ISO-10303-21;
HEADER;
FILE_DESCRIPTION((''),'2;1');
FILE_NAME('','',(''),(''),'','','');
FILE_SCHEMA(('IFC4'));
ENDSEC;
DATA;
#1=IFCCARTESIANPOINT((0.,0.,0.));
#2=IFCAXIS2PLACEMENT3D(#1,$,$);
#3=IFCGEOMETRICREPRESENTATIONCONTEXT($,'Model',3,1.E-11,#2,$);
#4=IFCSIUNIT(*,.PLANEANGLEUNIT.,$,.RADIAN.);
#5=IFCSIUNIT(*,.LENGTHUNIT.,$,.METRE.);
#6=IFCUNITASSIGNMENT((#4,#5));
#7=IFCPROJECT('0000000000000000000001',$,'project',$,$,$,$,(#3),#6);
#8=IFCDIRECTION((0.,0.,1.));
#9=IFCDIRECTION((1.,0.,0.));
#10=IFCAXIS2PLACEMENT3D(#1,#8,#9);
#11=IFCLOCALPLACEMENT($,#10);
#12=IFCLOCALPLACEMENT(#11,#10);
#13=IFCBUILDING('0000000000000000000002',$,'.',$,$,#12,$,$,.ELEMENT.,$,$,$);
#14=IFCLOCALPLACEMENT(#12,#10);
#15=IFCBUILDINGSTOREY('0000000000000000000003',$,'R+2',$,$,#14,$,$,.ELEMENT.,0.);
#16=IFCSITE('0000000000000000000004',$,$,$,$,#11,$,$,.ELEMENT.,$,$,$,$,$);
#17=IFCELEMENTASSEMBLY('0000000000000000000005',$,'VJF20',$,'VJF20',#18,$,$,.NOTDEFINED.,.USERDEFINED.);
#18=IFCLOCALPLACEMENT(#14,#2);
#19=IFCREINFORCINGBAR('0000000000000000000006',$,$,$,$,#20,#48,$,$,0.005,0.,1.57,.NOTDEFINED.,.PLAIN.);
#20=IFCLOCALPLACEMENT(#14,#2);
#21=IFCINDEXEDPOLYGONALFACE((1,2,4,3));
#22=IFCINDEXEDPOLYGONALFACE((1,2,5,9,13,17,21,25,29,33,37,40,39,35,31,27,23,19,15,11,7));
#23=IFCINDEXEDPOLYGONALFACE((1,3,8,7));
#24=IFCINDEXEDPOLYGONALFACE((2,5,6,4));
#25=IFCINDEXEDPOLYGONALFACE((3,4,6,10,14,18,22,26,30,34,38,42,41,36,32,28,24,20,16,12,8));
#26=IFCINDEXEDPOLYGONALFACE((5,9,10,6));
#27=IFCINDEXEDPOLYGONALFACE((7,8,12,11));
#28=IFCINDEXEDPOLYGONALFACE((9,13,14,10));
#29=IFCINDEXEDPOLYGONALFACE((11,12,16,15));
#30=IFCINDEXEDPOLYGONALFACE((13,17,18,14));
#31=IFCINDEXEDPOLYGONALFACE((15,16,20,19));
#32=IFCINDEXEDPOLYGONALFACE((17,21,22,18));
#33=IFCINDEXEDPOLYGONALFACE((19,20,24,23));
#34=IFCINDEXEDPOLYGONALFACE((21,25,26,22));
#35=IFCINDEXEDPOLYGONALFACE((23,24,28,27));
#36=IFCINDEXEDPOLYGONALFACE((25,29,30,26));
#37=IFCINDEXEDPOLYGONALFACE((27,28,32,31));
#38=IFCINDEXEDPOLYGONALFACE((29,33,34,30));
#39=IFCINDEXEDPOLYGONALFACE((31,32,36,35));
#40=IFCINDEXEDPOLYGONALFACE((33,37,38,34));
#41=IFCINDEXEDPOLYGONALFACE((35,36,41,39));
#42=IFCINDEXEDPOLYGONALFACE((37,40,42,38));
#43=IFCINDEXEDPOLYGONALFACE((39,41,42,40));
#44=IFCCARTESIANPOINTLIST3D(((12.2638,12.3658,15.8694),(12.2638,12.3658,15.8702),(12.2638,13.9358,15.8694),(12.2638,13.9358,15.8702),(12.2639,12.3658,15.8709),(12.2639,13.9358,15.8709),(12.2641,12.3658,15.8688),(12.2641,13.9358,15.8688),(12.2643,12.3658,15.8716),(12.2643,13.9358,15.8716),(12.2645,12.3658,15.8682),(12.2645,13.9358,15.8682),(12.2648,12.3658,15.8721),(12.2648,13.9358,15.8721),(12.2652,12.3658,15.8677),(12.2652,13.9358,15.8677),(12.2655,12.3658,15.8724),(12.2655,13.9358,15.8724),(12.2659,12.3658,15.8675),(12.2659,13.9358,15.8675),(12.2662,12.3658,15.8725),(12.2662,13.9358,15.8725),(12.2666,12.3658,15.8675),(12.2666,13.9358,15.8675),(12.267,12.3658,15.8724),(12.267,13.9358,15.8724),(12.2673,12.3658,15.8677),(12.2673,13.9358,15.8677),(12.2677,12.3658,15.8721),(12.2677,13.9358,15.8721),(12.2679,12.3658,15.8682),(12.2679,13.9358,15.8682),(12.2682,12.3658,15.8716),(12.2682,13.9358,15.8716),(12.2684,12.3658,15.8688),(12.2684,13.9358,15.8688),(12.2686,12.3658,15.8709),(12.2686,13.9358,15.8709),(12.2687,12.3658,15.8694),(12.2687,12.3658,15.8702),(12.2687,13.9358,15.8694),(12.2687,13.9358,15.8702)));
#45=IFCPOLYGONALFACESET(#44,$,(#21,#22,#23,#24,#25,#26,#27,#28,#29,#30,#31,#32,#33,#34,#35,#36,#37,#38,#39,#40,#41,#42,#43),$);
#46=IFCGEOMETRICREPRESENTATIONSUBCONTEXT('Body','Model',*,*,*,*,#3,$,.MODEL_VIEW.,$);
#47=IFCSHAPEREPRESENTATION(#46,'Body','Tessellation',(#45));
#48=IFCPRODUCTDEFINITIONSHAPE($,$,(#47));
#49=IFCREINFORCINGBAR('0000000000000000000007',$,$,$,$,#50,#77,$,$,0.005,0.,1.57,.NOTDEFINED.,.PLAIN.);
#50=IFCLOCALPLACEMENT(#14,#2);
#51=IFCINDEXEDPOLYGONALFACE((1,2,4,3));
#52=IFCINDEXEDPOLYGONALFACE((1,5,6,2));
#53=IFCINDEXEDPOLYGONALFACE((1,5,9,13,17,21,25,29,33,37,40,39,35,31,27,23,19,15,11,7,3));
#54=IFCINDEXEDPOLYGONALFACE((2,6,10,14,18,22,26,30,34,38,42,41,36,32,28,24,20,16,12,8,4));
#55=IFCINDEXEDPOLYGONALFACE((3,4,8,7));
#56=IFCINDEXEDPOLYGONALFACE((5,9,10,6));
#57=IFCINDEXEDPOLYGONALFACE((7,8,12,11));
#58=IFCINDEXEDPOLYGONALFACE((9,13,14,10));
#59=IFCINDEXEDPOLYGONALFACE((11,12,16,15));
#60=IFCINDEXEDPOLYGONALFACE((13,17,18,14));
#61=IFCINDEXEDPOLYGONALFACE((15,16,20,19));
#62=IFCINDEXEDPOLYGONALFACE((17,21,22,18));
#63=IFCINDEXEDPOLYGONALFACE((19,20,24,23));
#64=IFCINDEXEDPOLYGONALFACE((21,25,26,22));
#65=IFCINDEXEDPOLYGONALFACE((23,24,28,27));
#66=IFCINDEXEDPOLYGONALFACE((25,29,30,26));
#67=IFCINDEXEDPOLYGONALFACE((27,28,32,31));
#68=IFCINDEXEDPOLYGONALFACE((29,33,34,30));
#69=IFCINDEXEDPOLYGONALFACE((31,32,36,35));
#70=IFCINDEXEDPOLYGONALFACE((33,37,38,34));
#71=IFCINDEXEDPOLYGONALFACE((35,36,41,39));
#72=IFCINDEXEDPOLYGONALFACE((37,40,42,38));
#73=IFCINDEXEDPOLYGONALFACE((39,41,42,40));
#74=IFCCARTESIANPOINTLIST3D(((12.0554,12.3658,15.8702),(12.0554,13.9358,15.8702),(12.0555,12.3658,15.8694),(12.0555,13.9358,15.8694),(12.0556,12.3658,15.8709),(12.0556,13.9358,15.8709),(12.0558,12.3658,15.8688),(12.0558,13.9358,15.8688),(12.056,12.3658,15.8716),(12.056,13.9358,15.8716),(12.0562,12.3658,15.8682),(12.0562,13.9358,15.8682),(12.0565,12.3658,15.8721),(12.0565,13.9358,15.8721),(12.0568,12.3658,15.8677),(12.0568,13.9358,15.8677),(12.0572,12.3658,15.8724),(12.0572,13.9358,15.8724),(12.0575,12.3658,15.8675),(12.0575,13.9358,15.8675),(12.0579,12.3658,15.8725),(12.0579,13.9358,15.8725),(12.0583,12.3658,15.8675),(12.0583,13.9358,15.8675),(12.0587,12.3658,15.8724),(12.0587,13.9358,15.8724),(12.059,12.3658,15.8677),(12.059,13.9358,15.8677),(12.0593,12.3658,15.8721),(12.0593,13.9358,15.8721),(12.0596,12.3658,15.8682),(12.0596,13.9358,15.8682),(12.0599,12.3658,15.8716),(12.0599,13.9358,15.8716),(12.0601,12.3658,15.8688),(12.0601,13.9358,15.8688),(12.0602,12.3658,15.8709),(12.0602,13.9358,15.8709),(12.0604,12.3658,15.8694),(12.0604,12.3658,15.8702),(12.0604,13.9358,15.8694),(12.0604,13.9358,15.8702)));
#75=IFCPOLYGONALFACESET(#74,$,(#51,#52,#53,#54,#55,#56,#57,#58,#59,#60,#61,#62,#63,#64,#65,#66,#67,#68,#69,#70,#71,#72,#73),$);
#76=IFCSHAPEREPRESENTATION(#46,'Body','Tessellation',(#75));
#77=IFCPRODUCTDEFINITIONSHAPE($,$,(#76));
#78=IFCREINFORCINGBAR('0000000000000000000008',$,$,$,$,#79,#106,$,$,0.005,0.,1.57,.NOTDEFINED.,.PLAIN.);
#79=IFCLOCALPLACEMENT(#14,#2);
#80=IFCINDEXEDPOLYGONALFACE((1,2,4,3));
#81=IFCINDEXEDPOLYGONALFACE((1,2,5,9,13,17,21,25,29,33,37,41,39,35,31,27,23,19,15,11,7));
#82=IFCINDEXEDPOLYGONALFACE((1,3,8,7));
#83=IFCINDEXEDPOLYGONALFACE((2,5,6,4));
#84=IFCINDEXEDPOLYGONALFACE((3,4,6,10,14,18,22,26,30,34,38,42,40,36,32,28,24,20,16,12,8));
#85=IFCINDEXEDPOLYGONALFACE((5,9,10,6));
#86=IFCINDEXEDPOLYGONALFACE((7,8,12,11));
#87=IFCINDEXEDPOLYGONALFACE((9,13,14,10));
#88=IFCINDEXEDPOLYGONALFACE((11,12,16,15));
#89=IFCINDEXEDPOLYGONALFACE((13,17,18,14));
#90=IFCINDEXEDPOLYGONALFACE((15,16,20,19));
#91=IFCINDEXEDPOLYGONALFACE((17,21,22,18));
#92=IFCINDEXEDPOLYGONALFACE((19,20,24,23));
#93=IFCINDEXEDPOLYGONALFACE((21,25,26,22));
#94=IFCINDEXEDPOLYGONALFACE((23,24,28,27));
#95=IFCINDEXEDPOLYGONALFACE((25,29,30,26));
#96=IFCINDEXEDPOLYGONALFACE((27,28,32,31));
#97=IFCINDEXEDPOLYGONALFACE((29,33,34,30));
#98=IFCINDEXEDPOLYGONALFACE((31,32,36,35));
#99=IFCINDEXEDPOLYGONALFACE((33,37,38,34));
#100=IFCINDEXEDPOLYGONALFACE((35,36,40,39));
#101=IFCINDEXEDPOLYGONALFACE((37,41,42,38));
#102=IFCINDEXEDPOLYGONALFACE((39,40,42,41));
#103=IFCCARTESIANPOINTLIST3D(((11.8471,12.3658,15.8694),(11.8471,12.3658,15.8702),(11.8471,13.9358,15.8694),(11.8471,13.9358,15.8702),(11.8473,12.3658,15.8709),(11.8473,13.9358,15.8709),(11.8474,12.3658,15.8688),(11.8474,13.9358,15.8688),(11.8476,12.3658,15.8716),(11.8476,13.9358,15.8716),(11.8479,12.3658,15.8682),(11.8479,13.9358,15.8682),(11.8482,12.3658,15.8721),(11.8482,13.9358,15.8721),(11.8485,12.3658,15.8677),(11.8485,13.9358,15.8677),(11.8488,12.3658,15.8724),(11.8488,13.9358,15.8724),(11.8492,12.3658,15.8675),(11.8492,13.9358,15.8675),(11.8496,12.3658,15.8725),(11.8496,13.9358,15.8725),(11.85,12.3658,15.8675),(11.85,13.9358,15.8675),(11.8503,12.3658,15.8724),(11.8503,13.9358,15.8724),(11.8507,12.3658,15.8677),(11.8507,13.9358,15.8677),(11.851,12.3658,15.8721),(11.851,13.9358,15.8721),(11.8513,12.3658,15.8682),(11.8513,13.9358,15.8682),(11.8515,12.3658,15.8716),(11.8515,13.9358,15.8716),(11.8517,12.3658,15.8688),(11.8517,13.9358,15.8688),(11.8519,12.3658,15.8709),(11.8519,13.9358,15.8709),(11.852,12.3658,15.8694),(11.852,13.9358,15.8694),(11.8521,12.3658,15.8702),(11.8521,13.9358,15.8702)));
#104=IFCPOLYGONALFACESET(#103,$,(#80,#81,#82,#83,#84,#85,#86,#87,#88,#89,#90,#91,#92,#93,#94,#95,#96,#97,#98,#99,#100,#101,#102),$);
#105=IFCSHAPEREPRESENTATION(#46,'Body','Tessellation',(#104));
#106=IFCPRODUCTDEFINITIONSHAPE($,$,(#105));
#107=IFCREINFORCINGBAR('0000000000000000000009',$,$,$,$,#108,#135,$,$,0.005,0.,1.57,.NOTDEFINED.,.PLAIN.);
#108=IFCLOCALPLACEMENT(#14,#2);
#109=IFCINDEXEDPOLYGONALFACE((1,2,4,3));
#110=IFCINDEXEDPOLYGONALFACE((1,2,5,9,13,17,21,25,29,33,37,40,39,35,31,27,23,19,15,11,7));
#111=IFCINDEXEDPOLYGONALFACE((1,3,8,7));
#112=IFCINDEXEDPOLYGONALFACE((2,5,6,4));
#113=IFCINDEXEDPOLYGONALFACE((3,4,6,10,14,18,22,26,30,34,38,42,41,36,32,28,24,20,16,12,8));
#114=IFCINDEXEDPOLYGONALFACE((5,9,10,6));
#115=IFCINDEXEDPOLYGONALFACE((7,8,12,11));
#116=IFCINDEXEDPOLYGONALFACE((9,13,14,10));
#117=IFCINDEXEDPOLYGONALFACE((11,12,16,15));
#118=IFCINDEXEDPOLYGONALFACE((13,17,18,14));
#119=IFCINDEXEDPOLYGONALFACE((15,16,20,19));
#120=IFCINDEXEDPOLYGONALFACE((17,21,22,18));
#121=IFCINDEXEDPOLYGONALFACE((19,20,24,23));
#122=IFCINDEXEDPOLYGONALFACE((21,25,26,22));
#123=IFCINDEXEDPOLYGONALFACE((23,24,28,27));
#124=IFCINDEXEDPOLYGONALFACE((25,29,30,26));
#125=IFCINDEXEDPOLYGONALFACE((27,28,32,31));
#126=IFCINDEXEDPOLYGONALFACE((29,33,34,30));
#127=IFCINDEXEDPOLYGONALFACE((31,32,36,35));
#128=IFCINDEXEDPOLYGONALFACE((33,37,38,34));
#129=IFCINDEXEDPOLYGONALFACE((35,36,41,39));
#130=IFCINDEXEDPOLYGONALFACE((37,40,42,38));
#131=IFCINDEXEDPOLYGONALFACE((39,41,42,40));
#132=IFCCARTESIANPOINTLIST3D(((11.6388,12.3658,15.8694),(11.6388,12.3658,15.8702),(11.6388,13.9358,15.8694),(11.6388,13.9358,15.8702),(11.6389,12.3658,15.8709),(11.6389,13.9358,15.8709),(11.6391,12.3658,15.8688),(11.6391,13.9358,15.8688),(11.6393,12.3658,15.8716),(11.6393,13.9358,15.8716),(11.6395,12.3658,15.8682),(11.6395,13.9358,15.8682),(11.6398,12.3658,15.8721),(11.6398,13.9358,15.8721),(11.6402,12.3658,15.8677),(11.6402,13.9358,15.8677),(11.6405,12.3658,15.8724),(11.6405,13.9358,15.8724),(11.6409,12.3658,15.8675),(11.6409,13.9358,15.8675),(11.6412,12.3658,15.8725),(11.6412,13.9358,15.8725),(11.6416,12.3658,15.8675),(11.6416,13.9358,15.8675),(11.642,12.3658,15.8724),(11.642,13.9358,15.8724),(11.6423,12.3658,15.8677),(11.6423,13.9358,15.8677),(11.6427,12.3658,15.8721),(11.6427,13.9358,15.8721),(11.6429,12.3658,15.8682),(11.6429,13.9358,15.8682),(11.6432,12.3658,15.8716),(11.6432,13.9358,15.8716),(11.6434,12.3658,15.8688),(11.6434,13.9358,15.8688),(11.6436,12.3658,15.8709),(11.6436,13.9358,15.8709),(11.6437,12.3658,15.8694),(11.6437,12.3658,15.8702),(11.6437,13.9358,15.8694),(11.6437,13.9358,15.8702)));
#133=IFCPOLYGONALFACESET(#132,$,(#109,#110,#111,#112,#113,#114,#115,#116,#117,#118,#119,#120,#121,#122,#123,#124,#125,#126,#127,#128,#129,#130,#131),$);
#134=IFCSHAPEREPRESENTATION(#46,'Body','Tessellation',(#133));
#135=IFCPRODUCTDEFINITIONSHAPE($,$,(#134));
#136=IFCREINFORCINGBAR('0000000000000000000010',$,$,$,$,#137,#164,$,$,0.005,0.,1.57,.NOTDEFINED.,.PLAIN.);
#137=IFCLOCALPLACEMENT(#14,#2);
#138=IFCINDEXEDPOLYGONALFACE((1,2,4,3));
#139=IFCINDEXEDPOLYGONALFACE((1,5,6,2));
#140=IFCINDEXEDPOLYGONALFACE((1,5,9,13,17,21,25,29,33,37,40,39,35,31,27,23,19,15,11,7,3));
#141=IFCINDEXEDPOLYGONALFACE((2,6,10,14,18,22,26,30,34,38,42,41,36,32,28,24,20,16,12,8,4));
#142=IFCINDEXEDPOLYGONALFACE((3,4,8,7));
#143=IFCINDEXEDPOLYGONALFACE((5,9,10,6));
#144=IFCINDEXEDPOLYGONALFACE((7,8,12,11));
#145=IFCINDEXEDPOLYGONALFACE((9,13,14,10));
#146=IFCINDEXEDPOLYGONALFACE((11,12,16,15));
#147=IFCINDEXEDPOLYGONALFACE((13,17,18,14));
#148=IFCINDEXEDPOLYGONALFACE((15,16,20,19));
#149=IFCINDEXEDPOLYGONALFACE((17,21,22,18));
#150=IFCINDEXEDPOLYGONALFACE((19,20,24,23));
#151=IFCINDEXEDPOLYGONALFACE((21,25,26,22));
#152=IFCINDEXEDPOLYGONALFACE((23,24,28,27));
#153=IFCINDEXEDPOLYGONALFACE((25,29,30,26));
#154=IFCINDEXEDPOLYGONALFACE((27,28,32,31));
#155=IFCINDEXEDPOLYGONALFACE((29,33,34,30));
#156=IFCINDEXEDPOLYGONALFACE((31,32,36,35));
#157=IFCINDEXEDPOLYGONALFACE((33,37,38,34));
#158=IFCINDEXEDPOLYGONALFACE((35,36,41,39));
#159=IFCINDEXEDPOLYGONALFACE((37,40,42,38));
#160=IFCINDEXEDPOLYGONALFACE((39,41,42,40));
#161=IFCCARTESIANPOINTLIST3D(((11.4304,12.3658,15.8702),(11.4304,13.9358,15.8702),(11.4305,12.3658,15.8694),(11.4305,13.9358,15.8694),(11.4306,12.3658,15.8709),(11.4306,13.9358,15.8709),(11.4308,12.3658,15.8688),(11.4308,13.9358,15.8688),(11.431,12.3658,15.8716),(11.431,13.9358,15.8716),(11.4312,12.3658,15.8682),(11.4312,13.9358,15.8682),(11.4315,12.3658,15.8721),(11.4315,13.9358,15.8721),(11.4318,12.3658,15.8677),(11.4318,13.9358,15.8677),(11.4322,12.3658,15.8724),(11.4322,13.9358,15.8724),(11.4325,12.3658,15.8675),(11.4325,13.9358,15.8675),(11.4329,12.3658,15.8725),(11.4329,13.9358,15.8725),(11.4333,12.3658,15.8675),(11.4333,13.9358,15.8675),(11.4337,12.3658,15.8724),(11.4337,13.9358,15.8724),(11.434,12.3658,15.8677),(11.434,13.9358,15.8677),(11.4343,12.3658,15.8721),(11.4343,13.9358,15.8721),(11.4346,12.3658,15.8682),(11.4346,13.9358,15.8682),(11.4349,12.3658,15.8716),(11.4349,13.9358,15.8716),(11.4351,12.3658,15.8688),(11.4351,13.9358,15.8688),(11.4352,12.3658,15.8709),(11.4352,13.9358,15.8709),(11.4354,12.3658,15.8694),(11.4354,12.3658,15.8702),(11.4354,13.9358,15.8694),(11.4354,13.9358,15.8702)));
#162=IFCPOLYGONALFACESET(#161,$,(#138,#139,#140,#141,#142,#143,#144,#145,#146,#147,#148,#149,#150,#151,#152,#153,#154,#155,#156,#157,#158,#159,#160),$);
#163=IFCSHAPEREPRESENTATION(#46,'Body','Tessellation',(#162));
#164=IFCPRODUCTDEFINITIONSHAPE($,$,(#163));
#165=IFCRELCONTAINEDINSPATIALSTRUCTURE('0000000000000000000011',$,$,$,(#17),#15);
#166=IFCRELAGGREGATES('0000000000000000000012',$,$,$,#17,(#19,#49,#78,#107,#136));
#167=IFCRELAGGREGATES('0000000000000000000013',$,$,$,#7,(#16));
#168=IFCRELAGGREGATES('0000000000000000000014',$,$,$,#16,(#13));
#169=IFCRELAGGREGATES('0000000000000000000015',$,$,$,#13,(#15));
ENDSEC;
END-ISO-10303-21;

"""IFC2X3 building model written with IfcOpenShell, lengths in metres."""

from ifc_helpers import new_model, entity, si_unit, origin, origin_with_axes, place, context, subcontext, project, spatial, shape, element, aggregate, save


model = new_model("IFC2X3")

# Units and contexts
model_context = context("Model", 3, precision=1e-11, world=origin())
body_context = subcontext(model_context, "Body", "Model", "MODEL_VIEW")
ifc_project = project(units=[si_unit("PLANEANGLEUNIT", "RADIAN"), si_unit("LENGTHUNIT", "METRE")], contexts=[model_context])

# Site, building, storey
site_placement = place(None, origin_with_axes())
site = spatial("IfcSite", under=ifc_project, at=site_placement, CompositionType="ELEMENT")
building_placement = place(site_placement, origin_with_axes())
building = spatial("IfcBuilding", under=site, at=building_placement, Name=".", CompositionType="ELEMENT")
storey_placement = place(building_placement, origin_with_axes())
storey = spatial("IfcBuildingStorey", under=building, at=storey_placement, Name="R+2", CompositionType="ELEMENT", Elevation=0.0)

# Element assembly, reinforcing bars
assembly_1_placement = place(storey_placement, origin_with_axes())
assembly_1 = element("IfcElementAssembly", 1, at=assembly_1_placement, inside=storey, Name="VJF20", ObjectType="VJF20", AssemblyPlace="NOTDEFINED", PredefinedType="USERDEFINED")
reinforcing_bar_1_placement = place(assembly_1_placement, origin_with_axes())
reinforcing_bar_1 = element("IfcReinforcingBar", 2, at=reinforcing_bar_1_placement, BarLength=1.57, BarRole="NOTDEFINED", BarSurface="PLAIN", CrossSectionArea=0.0, NominalDiameter=0.005, shapes=[
    shape(body_context, "Body", "AdvancedSweptSolid", [entity("IfcSweptDiskSolid", entity("IfcPolyline", [entity("IfcCartesianPoint", [12.2662, 12.3658, 15.87]), entity("IfcCartesianPoint", [12.2662, 13.9358, 15.87])]), 0.0025, None, 0.0, 1.57)]),
    shape(body_context, "Body", "AdvancedSweptSolid", [entity("IfcSweptDiskSolid", entity("IfcPolyline", [entity("IfcCartesianPoint", [12.2662, 12.3658, 15.87]), entity("IfcCartesianPoint", [12.2662, 13.9358, 15.87])]), 0.0025, None, 0.0, 1.57)]),
])
reinforcing_bar_2_placement = place(assembly_1_placement, origin_with_axes())
reinforcing_bar_2 = element("IfcReinforcingBar", 3, at=reinforcing_bar_2_placement, BarLength=1.57, BarRole="NOTDEFINED", BarSurface="PLAIN", CrossSectionArea=0.0, NominalDiameter=0.005, shapes=[
    shape(body_context, "Body", "AdvancedSweptSolid", [entity("IfcSweptDiskSolid", entity("IfcPolyline", [entity("IfcCartesianPoint", [12.0579, 12.3658, 15.87]), entity("IfcCartesianPoint", [12.0579, 13.9358, 15.87])]), 0.0025, None, 0.0, 1.57)]),
    shape(body_context, "Body", "AdvancedSweptSolid", [entity("IfcSweptDiskSolid", entity("IfcPolyline", [entity("IfcCartesianPoint", [12.0579, 12.3658, 15.87]), entity("IfcCartesianPoint", [12.0579, 13.9358, 15.87])]), 0.0025, None, 0.0, 1.57)]),
])
reinforcing_bar_3_placement = place(assembly_1_placement, origin_with_axes())
reinforcing_bar_3 = element("IfcReinforcingBar", 4, at=reinforcing_bar_3_placement, BarLength=1.57, BarRole="NOTDEFINED", BarSurface="PLAIN", CrossSectionArea=0.0, NominalDiameter=0.005, shapes=[
    shape(body_context, "Body", "AdvancedSweptSolid", [entity("IfcSweptDiskSolid", entity("IfcPolyline", [entity("IfcCartesianPoint", [11.8496, 12.3658, 15.87]), entity("IfcCartesianPoint", [11.8496, 13.9358, 15.87])]), 0.0025, None, 0.0, 1.57)]),
    shape(body_context, "Body", "AdvancedSweptSolid", [entity("IfcSweptDiskSolid", entity("IfcPolyline", [entity("IfcCartesianPoint", [11.8496, 12.3658, 15.87]), entity("IfcCartesianPoint", [11.8496, 13.9358, 15.87])]), 0.0025, None, 0.0, 1.57)]),
])
reinforcing_bar_4_placement = place(assembly_1_placement, origin_with_axes())
reinforcing_bar_4 = element("IfcReinforcingBar", 5, at=reinforcing_bar_4_placement, BarLength=1.57, BarRole="NOTDEFINED", BarSurface="PLAIN", CrossSectionArea=0.0, NominalDiameter=0.005, shapes=[
    shape(body_context, "Body", "AdvancedSweptSolid", [entity("IfcSweptDiskSolid", entity("IfcPolyline", [entity("IfcCartesianPoint", [11.6412, 12.3658, 15.87]), entity("IfcCartesianPoint", [11.6412, 13.9358, 15.87])]), 0.0025, None, 0.0, 1.57)]),
    shape(body_context, "Body", "AdvancedSweptSolid", [entity("IfcSweptDiskSolid", entity("IfcPolyline", [entity("IfcCartesianPoint", [11.6412, 12.3658, 15.87]), entity("IfcCartesianPoint", [11.6412, 13.9358, 15.87])]), 0.0025, None, 0.0, 1.57)]),
])
reinforcing_bar_5_placement = place(assembly_1_placement, origin_with_axes())
reinforcing_bar_5 = element("IfcReinforcingBar", 6, at=reinforcing_bar_5_placement, BarLength=1.57, BarRole="NOTDEFINED", BarSurface="PLAIN", CrossSectionArea=0.0, NominalDiameter=0.005, shapes=[
    shape(body_context, "Body", "AdvancedSweptSolid", [entity("IfcSweptDiskSolid", entity("IfcPolyline", [entity("IfcCartesianPoint", [11.4329, 12.3658, 15.87]), entity("IfcCartesianPoint", [11.4329, 13.9358, 15.87])]), 0.0025, None, 0.0, 1.57)]),
    shape(body_context, "Body", "AdvancedSweptSolid", [entity("IfcSweptDiskSolid", entity("IfcPolyline", [entity("IfcCartesianPoint", [11.4329, 12.3658, 15.87]), entity("IfcCartesianPoint", [11.4329, 13.9358, 15.87])]), 0.0025, None, 0.0, 1.57)]),
])
aggregate(assembly_1, [reinforcing_bar_1, reinforcing_bar_2, reinforcing_bar_3, reinforcing_bar_4, reinforcing_bar_5])

save(model, "model.ifc")
